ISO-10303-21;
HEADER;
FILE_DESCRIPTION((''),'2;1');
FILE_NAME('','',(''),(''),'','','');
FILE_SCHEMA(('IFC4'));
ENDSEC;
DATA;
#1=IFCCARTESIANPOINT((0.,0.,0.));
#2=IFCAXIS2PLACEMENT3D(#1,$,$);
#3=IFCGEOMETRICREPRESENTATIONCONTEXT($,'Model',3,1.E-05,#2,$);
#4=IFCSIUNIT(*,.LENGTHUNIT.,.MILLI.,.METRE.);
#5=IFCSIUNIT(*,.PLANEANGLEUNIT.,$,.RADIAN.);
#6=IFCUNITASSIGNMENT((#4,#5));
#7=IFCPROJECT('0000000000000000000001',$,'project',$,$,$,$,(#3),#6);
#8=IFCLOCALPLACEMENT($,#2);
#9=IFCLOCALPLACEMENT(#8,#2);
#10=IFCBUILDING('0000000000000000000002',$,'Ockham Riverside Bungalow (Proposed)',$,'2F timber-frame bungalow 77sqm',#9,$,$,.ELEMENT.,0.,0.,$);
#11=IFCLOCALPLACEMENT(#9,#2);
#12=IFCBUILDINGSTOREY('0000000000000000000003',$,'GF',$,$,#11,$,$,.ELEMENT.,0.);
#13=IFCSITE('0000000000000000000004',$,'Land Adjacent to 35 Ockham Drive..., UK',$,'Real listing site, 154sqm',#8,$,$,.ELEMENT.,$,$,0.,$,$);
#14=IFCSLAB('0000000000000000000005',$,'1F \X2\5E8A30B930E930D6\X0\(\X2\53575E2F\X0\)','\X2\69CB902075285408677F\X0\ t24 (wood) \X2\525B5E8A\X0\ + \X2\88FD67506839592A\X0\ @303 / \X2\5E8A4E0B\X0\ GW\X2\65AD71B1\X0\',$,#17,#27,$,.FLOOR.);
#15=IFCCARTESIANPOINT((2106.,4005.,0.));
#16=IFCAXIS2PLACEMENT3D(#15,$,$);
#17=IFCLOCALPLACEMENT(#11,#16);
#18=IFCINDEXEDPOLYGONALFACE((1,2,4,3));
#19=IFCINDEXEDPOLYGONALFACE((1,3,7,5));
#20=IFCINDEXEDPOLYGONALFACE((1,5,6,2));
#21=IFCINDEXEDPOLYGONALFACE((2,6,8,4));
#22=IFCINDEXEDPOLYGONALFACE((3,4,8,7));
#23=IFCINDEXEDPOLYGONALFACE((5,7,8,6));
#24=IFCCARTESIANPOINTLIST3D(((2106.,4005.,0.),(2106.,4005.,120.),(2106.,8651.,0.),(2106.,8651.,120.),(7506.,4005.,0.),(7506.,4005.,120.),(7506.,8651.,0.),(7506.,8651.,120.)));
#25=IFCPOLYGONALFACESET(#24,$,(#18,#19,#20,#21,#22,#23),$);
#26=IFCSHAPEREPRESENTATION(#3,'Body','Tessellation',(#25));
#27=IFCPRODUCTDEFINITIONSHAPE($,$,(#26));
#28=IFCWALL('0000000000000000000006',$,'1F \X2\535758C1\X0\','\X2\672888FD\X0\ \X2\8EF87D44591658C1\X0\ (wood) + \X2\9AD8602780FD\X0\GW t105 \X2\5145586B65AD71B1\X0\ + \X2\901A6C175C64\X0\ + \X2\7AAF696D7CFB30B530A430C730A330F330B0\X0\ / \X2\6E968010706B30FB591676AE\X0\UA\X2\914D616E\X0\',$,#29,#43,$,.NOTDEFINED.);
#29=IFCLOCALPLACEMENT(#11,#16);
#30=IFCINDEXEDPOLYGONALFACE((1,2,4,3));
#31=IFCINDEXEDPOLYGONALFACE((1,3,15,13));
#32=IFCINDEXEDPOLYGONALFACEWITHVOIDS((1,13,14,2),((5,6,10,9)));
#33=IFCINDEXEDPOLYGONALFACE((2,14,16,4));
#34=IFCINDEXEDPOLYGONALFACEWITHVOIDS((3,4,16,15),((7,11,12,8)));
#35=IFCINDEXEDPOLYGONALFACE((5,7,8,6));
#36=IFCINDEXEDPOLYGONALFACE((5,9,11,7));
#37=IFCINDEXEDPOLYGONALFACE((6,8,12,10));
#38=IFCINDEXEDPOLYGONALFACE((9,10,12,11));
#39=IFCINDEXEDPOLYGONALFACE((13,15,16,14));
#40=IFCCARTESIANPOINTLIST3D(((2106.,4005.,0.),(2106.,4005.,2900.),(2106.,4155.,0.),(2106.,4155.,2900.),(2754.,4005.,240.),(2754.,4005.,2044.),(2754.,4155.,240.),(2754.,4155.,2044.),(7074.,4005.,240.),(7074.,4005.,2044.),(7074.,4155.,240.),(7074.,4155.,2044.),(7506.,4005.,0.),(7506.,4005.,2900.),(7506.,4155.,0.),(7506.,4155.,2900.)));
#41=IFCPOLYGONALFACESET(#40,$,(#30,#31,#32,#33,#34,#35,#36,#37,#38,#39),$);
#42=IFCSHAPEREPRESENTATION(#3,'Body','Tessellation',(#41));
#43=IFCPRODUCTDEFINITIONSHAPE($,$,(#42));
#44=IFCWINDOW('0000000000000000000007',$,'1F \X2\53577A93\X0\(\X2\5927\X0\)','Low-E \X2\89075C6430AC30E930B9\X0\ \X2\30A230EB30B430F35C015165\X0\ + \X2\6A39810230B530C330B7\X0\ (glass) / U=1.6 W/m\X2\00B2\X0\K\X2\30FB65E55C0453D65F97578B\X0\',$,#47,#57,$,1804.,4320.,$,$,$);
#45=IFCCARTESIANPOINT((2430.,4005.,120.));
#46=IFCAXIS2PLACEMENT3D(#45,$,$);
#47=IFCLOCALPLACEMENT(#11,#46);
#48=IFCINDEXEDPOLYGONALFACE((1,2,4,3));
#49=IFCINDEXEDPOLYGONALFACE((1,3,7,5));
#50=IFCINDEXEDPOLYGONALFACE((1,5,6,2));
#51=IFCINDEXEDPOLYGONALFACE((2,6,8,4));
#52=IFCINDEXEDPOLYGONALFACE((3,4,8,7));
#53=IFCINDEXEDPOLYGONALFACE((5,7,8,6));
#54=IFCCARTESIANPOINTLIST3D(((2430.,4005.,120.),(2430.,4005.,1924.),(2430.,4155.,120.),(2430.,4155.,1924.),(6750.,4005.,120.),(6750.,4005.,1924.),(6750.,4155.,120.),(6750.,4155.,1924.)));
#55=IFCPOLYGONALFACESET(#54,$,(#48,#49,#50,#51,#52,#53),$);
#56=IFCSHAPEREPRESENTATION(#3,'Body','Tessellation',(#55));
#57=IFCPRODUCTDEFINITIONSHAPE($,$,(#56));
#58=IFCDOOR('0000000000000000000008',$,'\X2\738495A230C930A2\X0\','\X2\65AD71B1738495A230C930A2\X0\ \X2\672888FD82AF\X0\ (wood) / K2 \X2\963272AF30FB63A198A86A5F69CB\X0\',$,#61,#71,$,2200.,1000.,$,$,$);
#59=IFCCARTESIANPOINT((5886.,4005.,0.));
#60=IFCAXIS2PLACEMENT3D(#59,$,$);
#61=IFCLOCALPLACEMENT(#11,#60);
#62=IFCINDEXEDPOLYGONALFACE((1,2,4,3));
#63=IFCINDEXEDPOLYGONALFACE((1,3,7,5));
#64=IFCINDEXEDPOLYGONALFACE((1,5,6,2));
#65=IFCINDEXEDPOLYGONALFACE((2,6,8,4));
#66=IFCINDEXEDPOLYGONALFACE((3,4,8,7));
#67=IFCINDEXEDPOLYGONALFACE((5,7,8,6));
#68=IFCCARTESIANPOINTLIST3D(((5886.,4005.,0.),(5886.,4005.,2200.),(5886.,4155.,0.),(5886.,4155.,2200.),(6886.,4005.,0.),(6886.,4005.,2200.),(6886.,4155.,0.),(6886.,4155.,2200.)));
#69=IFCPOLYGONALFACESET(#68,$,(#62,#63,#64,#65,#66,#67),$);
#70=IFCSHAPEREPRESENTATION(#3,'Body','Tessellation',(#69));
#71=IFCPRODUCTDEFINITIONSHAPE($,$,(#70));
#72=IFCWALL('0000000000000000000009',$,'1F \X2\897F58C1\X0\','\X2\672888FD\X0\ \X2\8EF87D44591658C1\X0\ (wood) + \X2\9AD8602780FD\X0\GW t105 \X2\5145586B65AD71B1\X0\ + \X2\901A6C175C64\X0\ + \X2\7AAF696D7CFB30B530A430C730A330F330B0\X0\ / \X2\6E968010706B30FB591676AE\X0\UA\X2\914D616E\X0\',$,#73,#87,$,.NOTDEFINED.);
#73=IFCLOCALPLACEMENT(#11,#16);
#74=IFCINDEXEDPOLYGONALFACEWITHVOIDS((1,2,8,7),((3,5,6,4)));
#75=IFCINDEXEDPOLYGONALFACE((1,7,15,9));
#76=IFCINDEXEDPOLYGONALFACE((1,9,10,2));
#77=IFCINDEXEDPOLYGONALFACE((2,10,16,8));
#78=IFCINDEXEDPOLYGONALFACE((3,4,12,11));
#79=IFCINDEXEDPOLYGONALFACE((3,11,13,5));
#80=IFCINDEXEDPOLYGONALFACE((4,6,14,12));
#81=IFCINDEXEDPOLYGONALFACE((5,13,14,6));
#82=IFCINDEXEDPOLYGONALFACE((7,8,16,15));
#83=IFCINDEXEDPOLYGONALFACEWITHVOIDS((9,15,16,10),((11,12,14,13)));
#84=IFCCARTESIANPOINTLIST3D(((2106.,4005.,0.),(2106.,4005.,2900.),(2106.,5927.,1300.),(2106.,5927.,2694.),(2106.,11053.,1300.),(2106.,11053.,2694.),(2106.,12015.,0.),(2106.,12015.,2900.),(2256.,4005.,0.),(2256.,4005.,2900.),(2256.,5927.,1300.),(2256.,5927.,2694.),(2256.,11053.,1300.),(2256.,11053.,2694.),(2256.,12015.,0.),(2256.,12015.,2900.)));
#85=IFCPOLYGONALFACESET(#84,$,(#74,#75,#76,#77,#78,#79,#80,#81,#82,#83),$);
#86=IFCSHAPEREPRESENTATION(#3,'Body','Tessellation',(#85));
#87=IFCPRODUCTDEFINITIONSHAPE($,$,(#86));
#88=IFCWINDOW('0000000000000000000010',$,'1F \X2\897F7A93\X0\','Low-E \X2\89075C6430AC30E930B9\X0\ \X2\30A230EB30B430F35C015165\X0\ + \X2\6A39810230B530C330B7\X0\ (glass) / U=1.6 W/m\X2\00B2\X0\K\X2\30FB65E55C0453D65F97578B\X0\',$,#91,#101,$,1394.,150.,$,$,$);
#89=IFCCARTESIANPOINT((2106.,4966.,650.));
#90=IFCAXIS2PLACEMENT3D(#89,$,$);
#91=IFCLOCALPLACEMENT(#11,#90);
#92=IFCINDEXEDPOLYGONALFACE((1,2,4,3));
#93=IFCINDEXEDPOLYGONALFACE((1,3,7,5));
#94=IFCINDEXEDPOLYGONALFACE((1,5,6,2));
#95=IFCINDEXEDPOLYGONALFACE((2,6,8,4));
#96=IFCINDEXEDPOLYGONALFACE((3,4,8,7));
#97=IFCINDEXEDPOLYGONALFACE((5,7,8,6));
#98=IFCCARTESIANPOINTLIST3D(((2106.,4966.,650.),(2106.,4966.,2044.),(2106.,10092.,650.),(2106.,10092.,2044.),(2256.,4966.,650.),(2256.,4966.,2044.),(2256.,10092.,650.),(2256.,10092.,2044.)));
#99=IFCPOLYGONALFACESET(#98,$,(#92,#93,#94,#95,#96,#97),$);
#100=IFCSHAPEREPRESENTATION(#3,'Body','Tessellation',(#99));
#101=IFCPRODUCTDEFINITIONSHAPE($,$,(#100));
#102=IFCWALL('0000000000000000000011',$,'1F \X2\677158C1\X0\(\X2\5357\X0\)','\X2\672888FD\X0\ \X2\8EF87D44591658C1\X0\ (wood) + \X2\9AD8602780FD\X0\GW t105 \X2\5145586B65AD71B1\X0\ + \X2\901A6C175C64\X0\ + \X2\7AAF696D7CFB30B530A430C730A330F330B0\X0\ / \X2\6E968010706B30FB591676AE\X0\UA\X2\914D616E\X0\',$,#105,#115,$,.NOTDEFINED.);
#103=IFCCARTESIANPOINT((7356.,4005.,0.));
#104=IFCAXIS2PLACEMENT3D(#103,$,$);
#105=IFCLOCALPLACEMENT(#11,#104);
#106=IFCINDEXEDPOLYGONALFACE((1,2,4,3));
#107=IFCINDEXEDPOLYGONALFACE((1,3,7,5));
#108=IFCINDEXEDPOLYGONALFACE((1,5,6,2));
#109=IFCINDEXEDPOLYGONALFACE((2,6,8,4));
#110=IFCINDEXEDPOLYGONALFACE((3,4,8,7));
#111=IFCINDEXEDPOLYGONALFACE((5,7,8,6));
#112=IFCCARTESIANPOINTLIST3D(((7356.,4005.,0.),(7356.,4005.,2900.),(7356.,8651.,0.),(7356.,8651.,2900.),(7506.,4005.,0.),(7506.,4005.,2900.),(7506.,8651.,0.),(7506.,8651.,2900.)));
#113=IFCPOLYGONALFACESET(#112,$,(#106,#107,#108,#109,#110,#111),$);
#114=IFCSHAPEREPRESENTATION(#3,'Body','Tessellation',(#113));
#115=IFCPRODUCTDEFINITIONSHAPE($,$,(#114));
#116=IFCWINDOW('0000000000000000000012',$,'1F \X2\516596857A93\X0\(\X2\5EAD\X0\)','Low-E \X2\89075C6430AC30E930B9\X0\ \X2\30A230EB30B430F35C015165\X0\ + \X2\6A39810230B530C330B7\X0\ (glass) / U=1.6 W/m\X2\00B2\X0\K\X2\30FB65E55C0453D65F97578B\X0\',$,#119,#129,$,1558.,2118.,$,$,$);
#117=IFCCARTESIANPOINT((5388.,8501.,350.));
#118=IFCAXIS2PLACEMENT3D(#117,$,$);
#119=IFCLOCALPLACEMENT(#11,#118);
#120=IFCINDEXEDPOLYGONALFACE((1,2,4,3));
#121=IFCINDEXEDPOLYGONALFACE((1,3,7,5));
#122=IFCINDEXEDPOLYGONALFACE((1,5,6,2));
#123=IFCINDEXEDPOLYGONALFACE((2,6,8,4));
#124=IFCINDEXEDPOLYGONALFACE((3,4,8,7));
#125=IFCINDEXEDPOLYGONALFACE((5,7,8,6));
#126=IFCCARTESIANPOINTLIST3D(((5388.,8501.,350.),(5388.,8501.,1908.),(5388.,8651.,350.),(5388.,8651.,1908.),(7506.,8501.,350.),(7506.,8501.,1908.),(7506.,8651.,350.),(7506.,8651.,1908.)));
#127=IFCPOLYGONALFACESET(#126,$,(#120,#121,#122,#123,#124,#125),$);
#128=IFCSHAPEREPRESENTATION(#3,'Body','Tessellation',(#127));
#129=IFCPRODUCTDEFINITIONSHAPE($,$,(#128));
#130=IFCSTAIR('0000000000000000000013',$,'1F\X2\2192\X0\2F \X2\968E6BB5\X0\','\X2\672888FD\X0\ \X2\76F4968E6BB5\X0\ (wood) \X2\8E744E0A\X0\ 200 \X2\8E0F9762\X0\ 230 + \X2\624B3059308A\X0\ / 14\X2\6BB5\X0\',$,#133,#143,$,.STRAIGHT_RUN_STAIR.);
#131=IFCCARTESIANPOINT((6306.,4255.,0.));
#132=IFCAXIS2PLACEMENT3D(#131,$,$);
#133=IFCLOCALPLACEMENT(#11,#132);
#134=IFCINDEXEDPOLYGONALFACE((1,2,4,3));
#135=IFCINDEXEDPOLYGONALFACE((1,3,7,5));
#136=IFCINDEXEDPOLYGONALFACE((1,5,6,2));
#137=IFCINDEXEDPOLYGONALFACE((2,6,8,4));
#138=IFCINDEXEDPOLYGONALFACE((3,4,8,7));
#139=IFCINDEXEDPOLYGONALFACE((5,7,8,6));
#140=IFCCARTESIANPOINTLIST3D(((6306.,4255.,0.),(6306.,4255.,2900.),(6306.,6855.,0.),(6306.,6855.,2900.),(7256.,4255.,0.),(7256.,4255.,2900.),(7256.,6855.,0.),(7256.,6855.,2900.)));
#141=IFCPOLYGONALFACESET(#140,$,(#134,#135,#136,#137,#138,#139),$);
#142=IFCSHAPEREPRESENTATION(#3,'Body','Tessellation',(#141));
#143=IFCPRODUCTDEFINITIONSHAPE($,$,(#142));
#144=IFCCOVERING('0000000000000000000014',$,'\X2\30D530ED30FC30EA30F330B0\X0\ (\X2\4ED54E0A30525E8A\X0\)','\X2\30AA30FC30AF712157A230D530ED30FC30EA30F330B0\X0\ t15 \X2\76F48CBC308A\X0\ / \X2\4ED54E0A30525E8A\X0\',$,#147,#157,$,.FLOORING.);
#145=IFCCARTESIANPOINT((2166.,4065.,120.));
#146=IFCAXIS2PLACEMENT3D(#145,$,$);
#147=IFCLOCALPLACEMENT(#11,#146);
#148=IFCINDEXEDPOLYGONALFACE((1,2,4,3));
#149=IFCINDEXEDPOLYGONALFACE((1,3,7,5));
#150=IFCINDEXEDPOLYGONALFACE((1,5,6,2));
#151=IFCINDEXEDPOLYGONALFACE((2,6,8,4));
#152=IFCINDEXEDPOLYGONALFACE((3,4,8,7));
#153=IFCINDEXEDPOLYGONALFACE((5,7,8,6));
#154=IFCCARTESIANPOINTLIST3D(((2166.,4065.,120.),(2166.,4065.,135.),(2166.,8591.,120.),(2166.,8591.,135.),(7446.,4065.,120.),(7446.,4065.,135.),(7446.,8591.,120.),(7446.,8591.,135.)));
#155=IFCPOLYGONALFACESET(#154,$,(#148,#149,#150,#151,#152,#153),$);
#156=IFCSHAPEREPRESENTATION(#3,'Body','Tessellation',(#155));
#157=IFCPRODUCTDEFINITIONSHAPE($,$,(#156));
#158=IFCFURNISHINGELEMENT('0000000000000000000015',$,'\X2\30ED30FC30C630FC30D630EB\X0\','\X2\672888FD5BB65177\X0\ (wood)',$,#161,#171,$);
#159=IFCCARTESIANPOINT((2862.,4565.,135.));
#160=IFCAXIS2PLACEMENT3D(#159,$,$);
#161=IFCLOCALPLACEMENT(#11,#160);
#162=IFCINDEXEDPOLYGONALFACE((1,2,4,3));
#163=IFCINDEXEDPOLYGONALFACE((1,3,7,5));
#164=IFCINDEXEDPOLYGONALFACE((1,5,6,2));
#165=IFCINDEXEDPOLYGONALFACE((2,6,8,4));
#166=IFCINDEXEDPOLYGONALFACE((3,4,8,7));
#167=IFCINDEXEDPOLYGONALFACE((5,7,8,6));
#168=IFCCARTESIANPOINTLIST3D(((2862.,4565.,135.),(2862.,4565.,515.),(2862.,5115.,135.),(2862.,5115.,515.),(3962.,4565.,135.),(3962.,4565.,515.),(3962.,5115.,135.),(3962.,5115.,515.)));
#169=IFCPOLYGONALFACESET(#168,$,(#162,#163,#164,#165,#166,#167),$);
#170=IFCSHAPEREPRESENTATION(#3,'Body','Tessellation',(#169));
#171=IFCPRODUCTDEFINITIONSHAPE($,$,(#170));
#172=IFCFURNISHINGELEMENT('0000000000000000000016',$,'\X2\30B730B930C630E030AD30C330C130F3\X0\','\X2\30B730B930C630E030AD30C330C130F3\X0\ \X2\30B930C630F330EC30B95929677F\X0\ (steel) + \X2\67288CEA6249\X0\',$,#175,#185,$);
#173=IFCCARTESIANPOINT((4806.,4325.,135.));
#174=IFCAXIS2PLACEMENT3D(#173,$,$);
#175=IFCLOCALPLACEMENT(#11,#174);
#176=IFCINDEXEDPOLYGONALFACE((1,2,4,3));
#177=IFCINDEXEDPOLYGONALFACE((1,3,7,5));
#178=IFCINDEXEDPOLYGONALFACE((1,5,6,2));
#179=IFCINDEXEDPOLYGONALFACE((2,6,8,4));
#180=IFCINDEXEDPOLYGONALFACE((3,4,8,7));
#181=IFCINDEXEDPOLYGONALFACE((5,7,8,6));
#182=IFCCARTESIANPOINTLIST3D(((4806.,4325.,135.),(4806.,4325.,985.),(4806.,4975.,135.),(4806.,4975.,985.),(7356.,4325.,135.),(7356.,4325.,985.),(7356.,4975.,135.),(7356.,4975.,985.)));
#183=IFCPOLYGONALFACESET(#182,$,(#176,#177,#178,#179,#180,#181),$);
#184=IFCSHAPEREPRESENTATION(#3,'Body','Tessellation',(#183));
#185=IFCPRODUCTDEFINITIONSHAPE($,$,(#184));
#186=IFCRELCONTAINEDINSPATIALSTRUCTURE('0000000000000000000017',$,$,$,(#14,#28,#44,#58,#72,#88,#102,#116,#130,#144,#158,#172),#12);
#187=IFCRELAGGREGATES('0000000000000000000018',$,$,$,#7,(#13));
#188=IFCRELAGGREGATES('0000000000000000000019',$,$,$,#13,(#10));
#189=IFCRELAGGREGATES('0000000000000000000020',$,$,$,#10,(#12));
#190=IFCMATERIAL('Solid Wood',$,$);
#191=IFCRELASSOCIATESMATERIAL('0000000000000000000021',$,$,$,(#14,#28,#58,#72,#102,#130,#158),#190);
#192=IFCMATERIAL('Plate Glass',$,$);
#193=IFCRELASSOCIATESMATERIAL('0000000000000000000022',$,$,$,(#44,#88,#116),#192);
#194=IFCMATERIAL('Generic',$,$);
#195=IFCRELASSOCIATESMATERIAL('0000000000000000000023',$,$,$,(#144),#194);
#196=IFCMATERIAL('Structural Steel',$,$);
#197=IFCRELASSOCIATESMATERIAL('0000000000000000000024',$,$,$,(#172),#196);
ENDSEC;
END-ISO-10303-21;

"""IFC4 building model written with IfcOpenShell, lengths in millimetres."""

from ifc_helpers import new_model, si_unit, frame, frame_2d, origin, place, context, project, spatial, rectangle, extrude, material, element, fill, save


model = new_model("IFC4")

# Units and contexts
model_context = context("Model", 3, precision=1e-05, world=origin())
ifc_project = project(units=[si_unit("LENGTHUNIT", "METRE", prefix="MILLI"), si_unit("PLANEANGLEUNIT", "RADIAN")], contexts=[model_context])

# Site, building, storey
site_placement = place(None, origin())
site = spatial("IfcSite", under=ifc_project, at=site_placement, Name="Land Adjacent to 35 Ockham Drive..., UK", ObjectType="Real listing site, 154sqm", CompositionType="ELEMENT", RefElevation=0.0)
building_placement = place(site_placement, origin())
building = spatial("IfcBuilding", under=site, at=building_placement, Name="Ockham Riverside Bungalow (Proposed)", ObjectType="2F timber-frame bungalow 77sqm", CompositionType="ELEMENT", ElevationOfRefHeight=0.0, ElevationOfTerrain=0.0)
storey_placement = place(building_placement, origin())
storey = spatial("IfcBuildingStorey", under=building, at=storey_placement, Name="GF", CompositionType="ELEMENT", Elevation=0.0)

# Slab
ifc_material_1 = material(Name="Solid Wood")
slab_1_placement = place(storey_placement, frame((2106.0, 4005.0, 0.0)))
element("IfcSlab", 1, at=slab_1_placement, inside=storey, material=ifc_material_1, Name="1F 床スラブ(南帯)", Description="構造用合板 t24 (wood) 剛床 + 製材根太 @303 / 床下 GW断熱", PredefinedType="FLOOR", context=model_context, shape_type="SweptSolid", body=[
    extrude(rectangle(XDim=5400.0, YDim=4646.0, at=frame_2d((2700.0, 2323.0))), frame((2106.0, 4005.0, 0.0)), (0.0, 0.0, 1.0), 120.0),
])

# Wall, openings, window, door
wall_1_placement = place(storey_placement, frame((2106.0, 4005.0, 0.0)))
wall_1 = element("IfcWall", 2, at=wall_1_placement, inside=storey, material=ifc_material_1, Name="1F 南壁", Description="木製 軸組外壁 (wood) + 高性能GW t105 充填断熱 + 通気層 + 窯業系サイディング / 準耐火・外皮UA配慮", PredefinedType="NOTDEFINED", context=model_context, shape_type="SweptSolid", body=[
    extrude(rectangle(XDim=5400.0, YDim=150.0, at=frame_2d((2700.0, 75.0))), frame((2106.0, 4005.0, 0.0)), (0.0, 0.0, 1.0), 2900.0),
])
opening_1_placement = place(storey_placement, frame((2430.0, 4005.0, 120.0)))
opening_1 = element("IfcOpeningElement", 3, at=opening_1_placement, cuts=wall_1, PredefinedType="NOTDEFINED", context=model_context, shape_type="SweptSolid", body=[
    extrude(rectangle(XDim=4320.0, YDim=150.0, at=frame_2d((2160.0, 75.0))), frame((2430.0, 4005.0, 120.0)), (0.0, 0.0, 1.0), 1804.0),
])
opening_2_placement = place(storey_placement, frame((5886.0, 4005.0, 0.0)))
opening_2 = element("IfcOpeningElement", 4, at=opening_2_placement, cuts=wall_1, PredefinedType="NOTDEFINED", context=model_context, shape_type="SweptSolid", body=[
    extrude(rectangle(XDim=1000.0, YDim=150.0, at=frame_2d((500.0, 75.0))), frame((5886.0, 4005.0, 0.0)), (0.0, 0.0, 1.0), 2200.0),
])
ifc_material_2 = material(Name="Plate Glass")
window_1_placement = place(storey_placement, frame((2430.0, 4005.0, 120.0)))
window_1 = element("IfcWindow", 5, at=window_1_placement, inside=storey, material=ifc_material_2, Name="1F 南窓(大)", Description="Low-E 複層ガラス アルゴン封入 + 樹脂サッシ (glass) / U=1.6 W/m²K・日射取得型", OverallHeight=1804.0, OverallWidth=4320.0, context=model_context, shape_type="SweptSolid", body=[
    extrude(rectangle(XDim=4320.0, YDim=150.0, at=frame_2d((2160.0, 75.0))), frame((2430.0, 4005.0, 120.0)), (0.0, 0.0, 1.0), 1804.0),
])
fill(opening_1, window_1)
door_1_placement = place(storey_placement, frame((5886.0, 4005.0, 0.0)))
door_1 = element("IfcDoor", 6, at=door_1_placement, inside=storey, material=ifc_material_1, Name="玄関ドア", Description="断熱玄関ドア 木製芯 (wood) / K2 防犯・採風機構", OverallHeight=2200.0, OverallWidth=1000.0, context=model_context, shape_type="SweptSolid", body=[
    extrude(rectangle(XDim=1000.0, YDim=150.0, at=frame_2d((500.0, 75.0))), frame((5886.0, 4005.0, 0.0)), (0.0, 0.0, 1.0), 2200.0),
])
fill(opening_2, door_1)

# Walls, openings, windows
wall_2_placement = place(storey_placement, frame((2106.0, 4005.0, 0.0)))
wall_2 = element("IfcWall", 7, at=wall_2_placement, inside=storey, material=ifc_material_1, Name="1F 西壁", Description="木製 軸組外壁 (wood) + 高性能GW t105 充填断熱 + 通気層 + 窯業系サイディング / 準耐火・外皮UA配慮", PredefinedType="NOTDEFINED", context=model_context, shape_type="SweptSolid", body=[
    extrude(rectangle(XDim=150.0, YDim=8010.0, at=frame_2d((75.0, 4005.0))), frame((2106.0, 4005.0, 0.0)), (0.0, 0.0, 1.0), 2900.0),
])
opening_3_placement = place(storey_placement, frame((2106.0, 4966.0, 650.0)))
opening_3 = element("IfcOpeningElement", 8, at=opening_3_placement, cuts=wall_2, PredefinedType="NOTDEFINED", context=model_context, shape_type="SweptSolid", body=[
    extrude(rectangle(XDim=150.0, YDim=5126.0, at=frame_2d((75.0, 2563.0))), frame((2106.0, 4966.0, 650.0)), (0.0, 0.0, 1.0), 1394.0),
])
window_2_placement = place(storey_placement, frame((2106.0, 4966.0, 650.0)))
window_2 = element("IfcWindow", 9, at=window_2_placement, inside=storey, material=ifc_material_2, Name="1F 西窓", Description="Low-E 複層ガラス アルゴン封入 + 樹脂サッシ (glass) / U=1.6 W/m²K・日射取得型", OverallHeight=1394.0, OverallWidth=150.0, context=model_context, shape_type="SweptSolid", body=[
    extrude(rectangle(XDim=150.0, YDim=5126.0, at=frame_2d((75.0, 2563.0))), frame((2106.0, 4966.0, 650.0)), (0.0, 0.0, 1.0), 1394.0),
])
fill(opening_3, window_2)
wall_3_placement = place(storey_placement, frame((7356.0, 4005.0, 0.0)))
wall_3 = element("IfcWall", 10, at=wall_3_placement, inside=storey, material=ifc_material_1, Name="1F 東壁(南)", Description="木製 軸組外壁 (wood) + 高性能GW t105 充填断熱 + 通気層 + 窯業系サイディング / 準耐火・外皮UA配慮", PredefinedType="NOTDEFINED", context=model_context, shape_type="SweptSolid", body=[
    extrude(rectangle(XDim=150.0, YDim=4646.0, at=frame_2d((75.0, 2323.0))), frame((7356.0, 4005.0, 0.0)), (0.0, 0.0, 1.0), 2900.0),
])
opening_4_placement = place(storey_placement, frame((5388.0, 8501.0, 350.0)))
opening_4 = element("IfcOpeningElement", 11, at=opening_4_placement, cuts=wall_3, PredefinedType="NOTDEFINED", context=model_context, shape_type="SweptSolid", body=[
    extrude(rectangle(XDim=2118.0, YDim=150.0, at=frame_2d((1059.0, 75.0))), frame((5388.0, 8501.0, 350.0)), (0.0, 0.0, 1.0), 1558.0),
])
window_3_placement = place(storey_placement, frame((5388.0, 8501.0, 350.0)))
window_3 = element("IfcWindow", 12, at=window_3_placement, inside=storey, material=ifc_material_2, Name="1F 入隅窓(庭)", Description="Low-E 複層ガラス アルゴン封入 + 樹脂サッシ (glass) / U=1.6 W/m²K・日射取得型", OverallHeight=1558.0, OverallWidth=2118.0, context=model_context, shape_type="SweptSolid", body=[
    extrude(rectangle(XDim=2118.0, YDim=150.0, at=frame_2d((1059.0, 75.0))), frame((5388.0, 8501.0, 350.0)), (0.0, 0.0, 1.0), 1558.0),
])
fill(opening_4, window_3)

# Stair
stair_placement = place(storey_placement, frame((6306.0, 4255.0, 0.0)))
element("IfcStair", 13, at=stair_placement, inside=storey, material=ifc_material_1, Name="1F→2F 階段", Description="木製 直階段 (wood) 蹴上 200 踏面 230 + 手すり / 14段", PredefinedType="STRAIGHT_RUN_STAIR", context=model_context, shape_type="SweptSolid", body=[
    extrude(rectangle(XDim=950.0, YDim=2600.0, at=frame_2d((475.0, 1300.0))), frame((6306.0, 4255.0, 0.0)), (0.0, 0.0, 1.0), 2900.0),
])

# Covering
ifc_material_3 = material(Name="Generic")
covering_placement = place(storey_placement, frame((2166.0, 4065.0, 120.0)))
element("IfcCovering", 14, at=covering_placement, inside=storey, material=ifc_material_3, Name="フローリング (仕上げ床)", Description="オーク無垢フローリング t15 直貼り / 仕上げ床", PredefinedType="FLOORING", context=model_context, shape_type="SweptSolid", body=[
    extrude(rectangle(XDim=5280.0, YDim=4526.0, at=frame_2d((2640.0, 2263.0))), frame((2166.0, 4065.0, 120.0)), (0.0, 0.0, 1.0), 15.0),
])

# Furnishing elements
furnishing_1_placement = place(storey_placement, frame((2862.0, 4565.0, 135.0)))
element("IfcFurnishingElement", 15, at=furnishing_1_placement, inside=storey, material=ifc_material_1, Name="ローテーブル", Description="木製家具 (wood)", context=model_context, shape_type="SweptSolid", body=[
    extrude(rectangle(XDim=1100.0, YDim=550.0, at=frame_2d((550.0, 275.0))), frame((2862.0, 4565.0, 135.0)), (0.0, 0.0, 1.0), 380.0),
])
ifc_material_4 = material(Name="Structural Steel")
furnishing_2_placement = place(storey_placement, frame((4806.0, 4325.0, 135.0)))
element("IfcFurnishingElement", 16, at=furnishing_2_placement, inside=storey, material=ifc_material_4, Name="システムキッチン", Description="システムキッチン ステンレス天板 (steel) + 木質扉", context=model_context, shape_type="SweptSolid", body=[
    extrude(rectangle(XDim=2550.0, YDim=650.0, at=frame_2d((1275.0, 325.0))), frame((4806.0, 4325.0, 135.0)), (0.0, 0.0, 1.0), 850.0),
])

save(model, "model.ifc")
